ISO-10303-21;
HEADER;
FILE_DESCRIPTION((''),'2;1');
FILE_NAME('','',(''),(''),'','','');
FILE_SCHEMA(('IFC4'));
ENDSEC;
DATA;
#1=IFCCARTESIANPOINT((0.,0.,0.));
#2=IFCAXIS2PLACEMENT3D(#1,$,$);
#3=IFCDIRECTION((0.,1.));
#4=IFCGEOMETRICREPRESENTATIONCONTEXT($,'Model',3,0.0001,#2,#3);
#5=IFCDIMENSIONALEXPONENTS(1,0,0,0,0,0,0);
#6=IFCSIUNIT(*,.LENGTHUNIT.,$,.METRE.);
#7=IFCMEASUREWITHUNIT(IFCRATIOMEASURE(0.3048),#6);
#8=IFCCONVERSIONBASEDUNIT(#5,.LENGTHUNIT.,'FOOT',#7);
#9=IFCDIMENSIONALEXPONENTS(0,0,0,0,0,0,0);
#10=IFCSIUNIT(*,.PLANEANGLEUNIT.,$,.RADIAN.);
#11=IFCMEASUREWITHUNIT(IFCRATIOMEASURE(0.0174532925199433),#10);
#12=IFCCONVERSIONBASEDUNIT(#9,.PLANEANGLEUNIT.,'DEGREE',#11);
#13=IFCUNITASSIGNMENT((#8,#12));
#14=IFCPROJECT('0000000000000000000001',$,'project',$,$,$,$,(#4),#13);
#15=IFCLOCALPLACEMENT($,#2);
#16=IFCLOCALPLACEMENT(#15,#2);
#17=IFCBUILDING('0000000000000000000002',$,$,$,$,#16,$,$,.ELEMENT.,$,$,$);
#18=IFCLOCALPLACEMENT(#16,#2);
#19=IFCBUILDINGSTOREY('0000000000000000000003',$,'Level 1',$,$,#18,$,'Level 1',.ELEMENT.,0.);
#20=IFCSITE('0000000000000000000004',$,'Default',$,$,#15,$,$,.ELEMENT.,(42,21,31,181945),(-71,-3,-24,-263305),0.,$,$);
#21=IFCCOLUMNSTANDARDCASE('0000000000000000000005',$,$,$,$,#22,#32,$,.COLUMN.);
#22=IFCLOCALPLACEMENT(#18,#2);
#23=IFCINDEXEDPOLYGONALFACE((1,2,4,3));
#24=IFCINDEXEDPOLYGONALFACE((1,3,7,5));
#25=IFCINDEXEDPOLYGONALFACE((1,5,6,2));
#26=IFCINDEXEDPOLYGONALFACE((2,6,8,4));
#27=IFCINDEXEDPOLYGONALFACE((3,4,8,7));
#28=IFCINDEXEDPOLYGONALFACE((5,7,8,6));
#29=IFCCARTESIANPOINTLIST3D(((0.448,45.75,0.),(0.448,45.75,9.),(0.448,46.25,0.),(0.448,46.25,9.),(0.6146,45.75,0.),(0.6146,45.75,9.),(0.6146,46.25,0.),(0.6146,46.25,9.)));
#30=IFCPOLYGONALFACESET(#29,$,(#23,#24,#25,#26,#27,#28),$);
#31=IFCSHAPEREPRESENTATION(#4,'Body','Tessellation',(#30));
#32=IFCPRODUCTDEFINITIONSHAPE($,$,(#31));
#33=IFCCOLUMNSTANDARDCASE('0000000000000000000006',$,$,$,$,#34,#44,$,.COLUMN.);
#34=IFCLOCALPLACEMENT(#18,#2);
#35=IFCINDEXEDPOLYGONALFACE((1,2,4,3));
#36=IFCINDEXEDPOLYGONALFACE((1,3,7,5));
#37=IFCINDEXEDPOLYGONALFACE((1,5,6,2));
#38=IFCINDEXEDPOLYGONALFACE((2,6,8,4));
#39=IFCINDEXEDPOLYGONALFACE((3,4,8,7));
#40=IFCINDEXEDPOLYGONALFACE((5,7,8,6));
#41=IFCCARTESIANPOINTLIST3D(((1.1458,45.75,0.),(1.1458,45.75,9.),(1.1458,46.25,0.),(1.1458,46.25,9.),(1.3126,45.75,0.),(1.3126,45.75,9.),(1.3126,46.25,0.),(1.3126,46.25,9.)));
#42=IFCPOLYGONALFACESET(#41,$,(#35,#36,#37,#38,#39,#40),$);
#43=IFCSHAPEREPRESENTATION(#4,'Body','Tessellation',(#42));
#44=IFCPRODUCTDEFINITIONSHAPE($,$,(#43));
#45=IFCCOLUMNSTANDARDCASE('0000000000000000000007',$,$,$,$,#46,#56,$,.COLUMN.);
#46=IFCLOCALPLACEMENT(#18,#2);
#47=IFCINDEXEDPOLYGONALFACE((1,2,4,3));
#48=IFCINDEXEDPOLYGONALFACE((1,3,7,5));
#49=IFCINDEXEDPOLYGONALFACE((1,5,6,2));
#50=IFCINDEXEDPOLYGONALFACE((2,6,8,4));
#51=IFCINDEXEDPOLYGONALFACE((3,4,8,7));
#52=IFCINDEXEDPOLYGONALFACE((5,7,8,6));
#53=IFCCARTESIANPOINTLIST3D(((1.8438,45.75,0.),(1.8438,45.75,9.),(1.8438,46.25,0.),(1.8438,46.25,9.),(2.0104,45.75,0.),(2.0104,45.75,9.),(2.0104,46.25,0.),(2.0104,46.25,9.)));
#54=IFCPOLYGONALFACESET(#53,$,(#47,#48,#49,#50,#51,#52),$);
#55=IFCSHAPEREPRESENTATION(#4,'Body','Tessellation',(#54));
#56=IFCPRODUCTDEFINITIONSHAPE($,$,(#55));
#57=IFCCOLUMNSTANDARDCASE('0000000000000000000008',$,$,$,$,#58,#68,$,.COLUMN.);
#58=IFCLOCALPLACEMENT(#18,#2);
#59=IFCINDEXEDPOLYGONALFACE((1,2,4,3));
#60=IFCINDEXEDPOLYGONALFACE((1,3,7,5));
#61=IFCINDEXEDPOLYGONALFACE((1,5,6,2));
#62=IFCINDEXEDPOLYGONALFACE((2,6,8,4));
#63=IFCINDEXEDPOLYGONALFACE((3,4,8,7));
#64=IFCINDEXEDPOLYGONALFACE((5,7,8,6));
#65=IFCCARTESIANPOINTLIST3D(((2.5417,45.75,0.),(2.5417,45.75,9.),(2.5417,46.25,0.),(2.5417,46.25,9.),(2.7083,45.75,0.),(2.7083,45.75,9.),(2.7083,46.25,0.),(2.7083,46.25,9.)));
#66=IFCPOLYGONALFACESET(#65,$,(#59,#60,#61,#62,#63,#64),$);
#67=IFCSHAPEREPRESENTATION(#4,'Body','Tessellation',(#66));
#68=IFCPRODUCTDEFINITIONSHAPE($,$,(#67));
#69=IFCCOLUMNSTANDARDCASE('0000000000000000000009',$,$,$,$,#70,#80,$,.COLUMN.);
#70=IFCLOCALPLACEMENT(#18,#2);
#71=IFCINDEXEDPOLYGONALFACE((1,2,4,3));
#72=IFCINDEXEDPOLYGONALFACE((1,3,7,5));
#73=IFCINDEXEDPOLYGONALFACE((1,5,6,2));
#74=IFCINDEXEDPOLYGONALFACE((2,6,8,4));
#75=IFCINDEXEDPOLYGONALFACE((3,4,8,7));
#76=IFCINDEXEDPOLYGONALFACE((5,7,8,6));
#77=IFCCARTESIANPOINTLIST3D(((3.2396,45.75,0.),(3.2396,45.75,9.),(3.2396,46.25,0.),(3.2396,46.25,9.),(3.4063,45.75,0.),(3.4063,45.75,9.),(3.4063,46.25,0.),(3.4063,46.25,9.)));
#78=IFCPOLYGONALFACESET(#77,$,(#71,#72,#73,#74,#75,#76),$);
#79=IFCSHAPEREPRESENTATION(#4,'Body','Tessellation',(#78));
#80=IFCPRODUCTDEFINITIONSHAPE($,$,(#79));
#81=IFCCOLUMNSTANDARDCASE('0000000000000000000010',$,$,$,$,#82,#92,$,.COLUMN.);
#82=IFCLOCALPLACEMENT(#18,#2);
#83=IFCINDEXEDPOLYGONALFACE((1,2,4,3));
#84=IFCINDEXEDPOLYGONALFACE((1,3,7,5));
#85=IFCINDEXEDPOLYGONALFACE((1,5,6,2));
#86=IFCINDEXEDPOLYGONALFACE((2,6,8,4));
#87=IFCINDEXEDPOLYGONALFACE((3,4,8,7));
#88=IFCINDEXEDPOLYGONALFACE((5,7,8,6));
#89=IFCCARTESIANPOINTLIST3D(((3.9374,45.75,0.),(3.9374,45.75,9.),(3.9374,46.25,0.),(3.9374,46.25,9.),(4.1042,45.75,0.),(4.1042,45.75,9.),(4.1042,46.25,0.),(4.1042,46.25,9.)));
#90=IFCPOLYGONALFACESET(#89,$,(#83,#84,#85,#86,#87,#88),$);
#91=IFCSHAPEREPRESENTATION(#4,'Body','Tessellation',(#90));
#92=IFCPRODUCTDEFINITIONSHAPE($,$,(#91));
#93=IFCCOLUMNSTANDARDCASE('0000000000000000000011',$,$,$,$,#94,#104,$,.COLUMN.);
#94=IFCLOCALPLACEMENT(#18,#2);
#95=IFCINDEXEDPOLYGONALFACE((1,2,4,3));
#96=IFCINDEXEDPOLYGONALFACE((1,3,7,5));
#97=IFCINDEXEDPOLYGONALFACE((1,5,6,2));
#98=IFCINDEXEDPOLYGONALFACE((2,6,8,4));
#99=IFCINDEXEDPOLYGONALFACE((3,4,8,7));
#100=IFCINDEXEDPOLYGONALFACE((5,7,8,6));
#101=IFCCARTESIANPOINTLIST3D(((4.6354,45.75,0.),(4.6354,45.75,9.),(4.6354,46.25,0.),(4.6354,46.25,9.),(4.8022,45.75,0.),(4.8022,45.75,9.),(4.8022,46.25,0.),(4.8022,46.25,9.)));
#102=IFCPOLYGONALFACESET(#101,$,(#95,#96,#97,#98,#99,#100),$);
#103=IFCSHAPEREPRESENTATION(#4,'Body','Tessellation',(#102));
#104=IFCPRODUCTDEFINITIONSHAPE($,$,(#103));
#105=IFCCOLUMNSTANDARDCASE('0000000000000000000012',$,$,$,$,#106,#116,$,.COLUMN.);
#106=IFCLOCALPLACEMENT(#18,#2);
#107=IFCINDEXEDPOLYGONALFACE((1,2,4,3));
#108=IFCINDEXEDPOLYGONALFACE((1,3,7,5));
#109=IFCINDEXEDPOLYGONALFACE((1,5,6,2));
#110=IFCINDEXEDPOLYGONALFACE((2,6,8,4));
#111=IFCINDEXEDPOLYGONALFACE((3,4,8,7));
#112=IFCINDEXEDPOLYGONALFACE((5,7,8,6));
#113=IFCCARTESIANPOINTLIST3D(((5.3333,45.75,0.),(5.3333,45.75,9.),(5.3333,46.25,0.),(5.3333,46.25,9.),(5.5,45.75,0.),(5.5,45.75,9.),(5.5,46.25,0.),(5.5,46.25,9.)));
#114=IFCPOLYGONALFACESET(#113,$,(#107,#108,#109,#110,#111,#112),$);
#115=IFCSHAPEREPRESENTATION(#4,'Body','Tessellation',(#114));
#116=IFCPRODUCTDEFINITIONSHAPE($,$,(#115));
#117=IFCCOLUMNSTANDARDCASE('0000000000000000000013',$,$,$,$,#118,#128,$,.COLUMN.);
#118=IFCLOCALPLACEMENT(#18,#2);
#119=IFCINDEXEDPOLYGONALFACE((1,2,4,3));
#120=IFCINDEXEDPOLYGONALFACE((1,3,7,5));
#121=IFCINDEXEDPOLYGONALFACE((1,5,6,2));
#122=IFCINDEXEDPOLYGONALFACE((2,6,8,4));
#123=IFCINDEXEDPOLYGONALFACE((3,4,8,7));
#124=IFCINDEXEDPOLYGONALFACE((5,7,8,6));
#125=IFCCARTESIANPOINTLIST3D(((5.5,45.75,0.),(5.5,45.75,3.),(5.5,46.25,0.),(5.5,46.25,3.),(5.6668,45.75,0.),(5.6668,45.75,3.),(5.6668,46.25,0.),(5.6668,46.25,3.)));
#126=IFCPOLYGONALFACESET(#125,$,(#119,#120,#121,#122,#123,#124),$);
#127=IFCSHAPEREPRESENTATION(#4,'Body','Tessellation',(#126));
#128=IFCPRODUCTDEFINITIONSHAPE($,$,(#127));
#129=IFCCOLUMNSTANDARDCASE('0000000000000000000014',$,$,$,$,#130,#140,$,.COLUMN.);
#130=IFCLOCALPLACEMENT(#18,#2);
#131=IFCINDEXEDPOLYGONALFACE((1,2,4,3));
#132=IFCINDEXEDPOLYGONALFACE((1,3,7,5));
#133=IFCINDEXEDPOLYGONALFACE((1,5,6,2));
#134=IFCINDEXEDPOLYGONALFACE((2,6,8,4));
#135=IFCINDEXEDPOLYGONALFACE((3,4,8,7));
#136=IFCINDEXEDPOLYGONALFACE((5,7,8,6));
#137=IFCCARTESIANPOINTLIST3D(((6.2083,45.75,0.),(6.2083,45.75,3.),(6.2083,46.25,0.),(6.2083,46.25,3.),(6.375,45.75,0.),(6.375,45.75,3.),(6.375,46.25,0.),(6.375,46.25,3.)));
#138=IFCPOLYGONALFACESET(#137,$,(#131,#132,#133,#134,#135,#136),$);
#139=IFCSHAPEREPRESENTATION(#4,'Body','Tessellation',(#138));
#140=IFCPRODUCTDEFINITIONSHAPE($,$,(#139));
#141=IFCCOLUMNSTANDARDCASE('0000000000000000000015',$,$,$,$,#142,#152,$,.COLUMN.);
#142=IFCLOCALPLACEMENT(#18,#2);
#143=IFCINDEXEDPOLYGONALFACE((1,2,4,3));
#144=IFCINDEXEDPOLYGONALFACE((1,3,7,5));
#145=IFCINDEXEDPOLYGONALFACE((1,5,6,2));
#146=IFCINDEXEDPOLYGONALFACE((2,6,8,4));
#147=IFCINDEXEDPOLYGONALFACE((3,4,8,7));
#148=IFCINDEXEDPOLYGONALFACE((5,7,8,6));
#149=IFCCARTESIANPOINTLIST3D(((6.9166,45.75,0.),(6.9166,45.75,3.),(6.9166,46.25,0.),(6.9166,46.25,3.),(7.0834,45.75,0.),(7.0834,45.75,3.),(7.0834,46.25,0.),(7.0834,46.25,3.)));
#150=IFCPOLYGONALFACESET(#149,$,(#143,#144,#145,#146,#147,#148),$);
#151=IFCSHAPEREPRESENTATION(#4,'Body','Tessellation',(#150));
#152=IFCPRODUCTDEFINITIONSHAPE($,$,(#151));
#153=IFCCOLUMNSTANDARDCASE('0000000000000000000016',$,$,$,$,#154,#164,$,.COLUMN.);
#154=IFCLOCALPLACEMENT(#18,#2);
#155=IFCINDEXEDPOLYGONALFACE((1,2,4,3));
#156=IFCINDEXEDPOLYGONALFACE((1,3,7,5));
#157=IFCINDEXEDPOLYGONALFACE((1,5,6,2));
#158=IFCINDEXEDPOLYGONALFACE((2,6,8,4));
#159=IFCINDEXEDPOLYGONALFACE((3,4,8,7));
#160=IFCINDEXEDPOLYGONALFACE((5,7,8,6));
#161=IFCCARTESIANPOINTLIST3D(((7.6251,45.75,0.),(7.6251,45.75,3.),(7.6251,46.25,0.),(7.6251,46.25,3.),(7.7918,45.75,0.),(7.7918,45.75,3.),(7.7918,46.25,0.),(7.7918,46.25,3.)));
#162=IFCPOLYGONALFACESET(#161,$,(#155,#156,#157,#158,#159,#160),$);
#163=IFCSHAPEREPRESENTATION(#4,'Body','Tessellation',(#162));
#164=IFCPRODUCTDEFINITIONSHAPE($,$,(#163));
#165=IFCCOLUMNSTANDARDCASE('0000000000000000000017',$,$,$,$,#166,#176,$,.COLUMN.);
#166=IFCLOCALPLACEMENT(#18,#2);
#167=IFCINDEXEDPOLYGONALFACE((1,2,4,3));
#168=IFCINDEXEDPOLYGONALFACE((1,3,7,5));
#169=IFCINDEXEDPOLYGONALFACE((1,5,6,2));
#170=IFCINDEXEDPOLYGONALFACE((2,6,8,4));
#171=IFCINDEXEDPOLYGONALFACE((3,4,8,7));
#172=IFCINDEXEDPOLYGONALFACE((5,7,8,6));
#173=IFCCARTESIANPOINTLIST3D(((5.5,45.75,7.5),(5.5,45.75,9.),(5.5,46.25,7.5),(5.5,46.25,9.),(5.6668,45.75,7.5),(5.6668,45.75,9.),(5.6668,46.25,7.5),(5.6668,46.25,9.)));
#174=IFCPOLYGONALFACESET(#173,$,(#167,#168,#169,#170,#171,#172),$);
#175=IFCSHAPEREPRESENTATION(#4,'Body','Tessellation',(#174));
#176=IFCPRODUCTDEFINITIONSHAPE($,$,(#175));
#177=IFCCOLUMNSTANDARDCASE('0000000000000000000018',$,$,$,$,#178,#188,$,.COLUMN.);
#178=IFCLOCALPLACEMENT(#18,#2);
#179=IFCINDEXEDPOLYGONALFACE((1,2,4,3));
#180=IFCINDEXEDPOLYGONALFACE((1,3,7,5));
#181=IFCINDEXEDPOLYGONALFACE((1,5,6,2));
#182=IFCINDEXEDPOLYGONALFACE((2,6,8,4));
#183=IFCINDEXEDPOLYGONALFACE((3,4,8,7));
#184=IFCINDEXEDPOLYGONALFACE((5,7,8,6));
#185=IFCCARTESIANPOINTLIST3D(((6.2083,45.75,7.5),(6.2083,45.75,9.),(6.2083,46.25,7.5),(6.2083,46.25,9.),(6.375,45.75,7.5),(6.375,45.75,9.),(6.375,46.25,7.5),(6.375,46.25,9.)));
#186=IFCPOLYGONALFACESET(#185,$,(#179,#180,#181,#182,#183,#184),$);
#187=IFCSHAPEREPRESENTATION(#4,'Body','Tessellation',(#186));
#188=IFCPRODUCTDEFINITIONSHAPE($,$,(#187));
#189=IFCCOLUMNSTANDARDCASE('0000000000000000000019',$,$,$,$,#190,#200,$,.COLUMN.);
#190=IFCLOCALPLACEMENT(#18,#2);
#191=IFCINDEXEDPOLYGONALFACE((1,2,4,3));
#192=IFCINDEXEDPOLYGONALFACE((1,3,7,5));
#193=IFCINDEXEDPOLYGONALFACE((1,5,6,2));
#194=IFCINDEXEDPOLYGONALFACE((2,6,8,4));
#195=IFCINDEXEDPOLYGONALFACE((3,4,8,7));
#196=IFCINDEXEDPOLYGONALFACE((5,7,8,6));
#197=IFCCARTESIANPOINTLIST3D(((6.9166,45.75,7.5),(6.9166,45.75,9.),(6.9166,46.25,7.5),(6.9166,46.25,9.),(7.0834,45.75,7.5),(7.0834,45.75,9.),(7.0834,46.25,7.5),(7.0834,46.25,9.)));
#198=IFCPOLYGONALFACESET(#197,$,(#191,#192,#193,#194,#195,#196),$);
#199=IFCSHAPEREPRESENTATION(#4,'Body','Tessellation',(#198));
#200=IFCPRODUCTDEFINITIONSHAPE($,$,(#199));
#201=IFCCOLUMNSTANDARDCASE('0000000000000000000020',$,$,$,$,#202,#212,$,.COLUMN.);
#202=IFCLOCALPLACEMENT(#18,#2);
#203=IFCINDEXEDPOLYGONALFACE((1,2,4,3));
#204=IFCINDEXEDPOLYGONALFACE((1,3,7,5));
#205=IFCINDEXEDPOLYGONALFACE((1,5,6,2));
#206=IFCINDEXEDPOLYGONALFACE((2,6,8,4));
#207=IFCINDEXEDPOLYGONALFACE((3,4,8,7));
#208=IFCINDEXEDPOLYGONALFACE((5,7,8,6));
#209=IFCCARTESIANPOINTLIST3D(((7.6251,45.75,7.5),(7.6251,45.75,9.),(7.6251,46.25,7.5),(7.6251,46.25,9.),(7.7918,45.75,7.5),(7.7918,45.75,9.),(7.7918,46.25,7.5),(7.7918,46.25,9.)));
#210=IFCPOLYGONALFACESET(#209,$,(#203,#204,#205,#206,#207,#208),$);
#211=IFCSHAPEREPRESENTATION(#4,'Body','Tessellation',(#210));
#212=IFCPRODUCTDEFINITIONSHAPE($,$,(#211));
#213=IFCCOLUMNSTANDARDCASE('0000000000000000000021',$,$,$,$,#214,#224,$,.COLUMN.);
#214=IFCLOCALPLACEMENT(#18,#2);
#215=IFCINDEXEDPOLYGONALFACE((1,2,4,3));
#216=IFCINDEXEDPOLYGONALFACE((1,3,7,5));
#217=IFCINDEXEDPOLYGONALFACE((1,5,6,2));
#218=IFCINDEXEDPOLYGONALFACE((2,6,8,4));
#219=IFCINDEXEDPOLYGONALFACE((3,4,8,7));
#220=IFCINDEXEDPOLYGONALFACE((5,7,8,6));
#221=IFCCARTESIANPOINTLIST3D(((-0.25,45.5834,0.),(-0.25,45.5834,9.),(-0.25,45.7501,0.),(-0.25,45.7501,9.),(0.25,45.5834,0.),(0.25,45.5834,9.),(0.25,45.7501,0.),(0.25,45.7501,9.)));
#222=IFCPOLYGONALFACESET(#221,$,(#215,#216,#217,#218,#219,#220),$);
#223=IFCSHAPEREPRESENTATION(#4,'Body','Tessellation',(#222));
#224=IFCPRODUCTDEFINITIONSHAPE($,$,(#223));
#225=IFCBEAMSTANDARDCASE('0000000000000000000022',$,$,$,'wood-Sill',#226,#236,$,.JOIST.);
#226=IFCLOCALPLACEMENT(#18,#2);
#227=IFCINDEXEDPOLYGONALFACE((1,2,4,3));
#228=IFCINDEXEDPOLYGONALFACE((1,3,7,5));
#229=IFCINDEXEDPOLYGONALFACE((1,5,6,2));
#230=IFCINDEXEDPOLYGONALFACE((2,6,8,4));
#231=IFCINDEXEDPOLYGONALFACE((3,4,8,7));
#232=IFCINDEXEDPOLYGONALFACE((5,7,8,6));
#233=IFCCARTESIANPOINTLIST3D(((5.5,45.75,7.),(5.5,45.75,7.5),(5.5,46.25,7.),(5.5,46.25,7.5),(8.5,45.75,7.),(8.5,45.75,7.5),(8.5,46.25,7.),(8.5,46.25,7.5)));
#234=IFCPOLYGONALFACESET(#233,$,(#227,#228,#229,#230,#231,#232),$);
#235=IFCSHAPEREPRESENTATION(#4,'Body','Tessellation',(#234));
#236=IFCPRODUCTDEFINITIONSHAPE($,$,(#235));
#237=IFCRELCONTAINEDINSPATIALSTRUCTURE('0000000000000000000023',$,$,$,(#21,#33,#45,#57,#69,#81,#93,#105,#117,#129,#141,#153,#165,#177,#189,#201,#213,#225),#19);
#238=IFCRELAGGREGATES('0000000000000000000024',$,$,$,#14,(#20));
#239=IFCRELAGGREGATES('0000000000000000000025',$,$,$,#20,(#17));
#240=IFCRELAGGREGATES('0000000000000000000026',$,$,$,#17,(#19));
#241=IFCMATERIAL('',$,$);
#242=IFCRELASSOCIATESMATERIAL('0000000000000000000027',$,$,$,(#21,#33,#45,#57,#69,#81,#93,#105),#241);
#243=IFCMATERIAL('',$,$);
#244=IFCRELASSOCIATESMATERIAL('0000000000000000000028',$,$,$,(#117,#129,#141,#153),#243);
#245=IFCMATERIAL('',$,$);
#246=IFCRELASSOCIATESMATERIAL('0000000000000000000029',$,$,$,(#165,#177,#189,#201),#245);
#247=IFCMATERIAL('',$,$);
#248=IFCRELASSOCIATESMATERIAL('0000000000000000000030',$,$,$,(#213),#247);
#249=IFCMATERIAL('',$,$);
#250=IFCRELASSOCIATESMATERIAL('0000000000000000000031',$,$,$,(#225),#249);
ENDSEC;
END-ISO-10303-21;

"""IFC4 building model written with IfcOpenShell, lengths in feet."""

from ifc_helpers import new_model, entity, si_unit, converted_unit, direction, frame, origin, place, context, project, spatial, rectangle, extrude, material, element, save


model = new_model("IFC4")

# Units and contexts
model_context = context("Model", 3, precision=0.0001, world=origin(), true_north=direction((0.0, 1.0)))
ifc_project = project(units=[converted_unit("LENGTHUNIT", "FOOT", entity("IfcRatioMeasure", 0.3048), si_unit("LENGTHUNIT", "METRE"), dimensions=[1, 0, 0, 0, 0, 0, 0]), converted_unit("PLANEANGLEUNIT", "DEGREE", entity("IfcRatioMeasure", 0.0174532925199433), si_unit("PLANEANGLEUNIT", "RADIAN"), dimensions=[0, 0, 0, 0, 0, 0, 0])], contexts=[model_context])

# Site, building, storey
site_placement = place(None, origin())
site = spatial("IfcSite", under=ifc_project, at=site_placement, Name="Default", CompositionType="ELEMENT", RefLatitude=(42, 21, 31, 181945), RefLongitude=(-71, -3, -24, -263305), RefElevation=0.0)
building_placement = place(site_placement, origin())
building = spatial("IfcBuilding", under=site, at=building_placement, CompositionType="ELEMENT")
storey_placement = place(building_placement, origin())
storey = spatial("IfcBuildingStorey", under=building, at=storey_placement, Name="Level 1", LongName="Level 1", CompositionType="ELEMENT", Elevation=0.0)

# Columns
ifc_material_1 = material(Name="")
placement_1 = place(storey_placement, frame((-0.25, 46.0, 0.0)))
for number, where, z_axis, x_axis in (
    (1, (0.7813, 0.0, 0.0), (0.0, 0.0, 1.0), (1.0, 0.0, 0.0)),
    (2, (1.4792, 0.0, 0.0), (0.0, 0.0, 1.0), (1.0, 0.0, 0.0)),
    (3, (2.1771, 0.0, 0.0), (0.0, 0.0, 1.0), (1.0, 0.0, 0.0)),
    (4, (2.875, 0.0, 0.0), (0.0, 0.0, 1.0), (1.0, 0.0, 0.0)),
    (5, (3.5729, 0.0, 0.0), (0.0, 0.0, 1.0), (1.0, 0.0, 0.0)),
    (6, (4.2708, 0.0, 0.0), (0.0, 0.0, 1.0), (1.0, 0.0, 0.0)),
    (7, (4.9688, 0.0, 0.0), (0.0, 0.0, 1.0), (1.0, 0.0, 0.0)),
    (8, (5.6667, 0.0, 0.0), (0.0, 0.0, 1.0), (1.0, 0.0, 0.0)),
):
    element("IfcColumnStandardCase", number, at=place(placement_1, frame(where, z_axis=z_axis, x_axis=x_axis)), inside=storey, material=ifc_material_1, PredefinedType="COLUMN", context=model_context, shape_type="SweptSolid", body=[
        extrude(rectangle(XDim=0.1667, YDim=0.5), origin(), (0.0, 0.0, 1.0), 9.0),
    ])
ifc_material_2 = material(Name="")
for number, where, z_axis, x_axis in (
    (9, (5.8334, 0.0, 0.0), (0.0, 0.0, 1.0), (1.0, 0.0, 0.0)),
    (10, (6.5417, 0.0, 0.0), (0.0, 0.0, 1.0), (1.0, 0.0, 0.0)),
    (11, (7.25, 0.0, 0.0), (0.0, 0.0, 1.0), (1.0, 0.0, 0.0)),
    (12, (7.9584, 0.0, 0.0), (0.0, 0.0, 1.0), (1.0, 0.0, 0.0)),
):
    element("IfcColumnStandardCase", number, at=place(placement_1, frame(where, z_axis=z_axis, x_axis=x_axis)), inside=storey, material=ifc_material_2, PredefinedType="COLUMN", context=model_context, shape_type="SweptSolid", body=[
        extrude(rectangle(XDim=0.1667, YDim=0.5), origin(), (0.0, 0.0, 1.0), 3.0),
    ])
ifc_material_3 = material(Name="")
for number, where, z_axis, x_axis in (
    (13, (5.8334, 0.0, 7.5), (0.0, 0.0, 1.0), (1.0, 0.0, 0.0)),
    (14, (6.5417, 0.0, 7.5), (0.0, 0.0, 1.0), (1.0, 0.0, 0.0)),
    (15, (7.25, 0.0, 7.5), (0.0, 0.0, 1.0), (1.0, 0.0, 0.0)),
    (16, (7.9584, 0.0, 7.5), (0.0, 0.0, 1.0), (1.0, 0.0, 0.0)),
):
    element("IfcColumnStandardCase", number, at=place(placement_1, frame(where, z_axis=z_axis, x_axis=x_axis)), inside=storey, material=ifc_material_3, PredefinedType="COLUMN", context=model_context, shape_type="SweptSolid", body=[
        extrude(rectangle(XDim=0.1667, YDim=0.5), origin(), (0.0, 0.0, 1.0), 1.5),
    ])
ifc_material_4 = material(Name="")
placement_2 = place(storey_placement, frame((0.0, -0.25, 0.0), z_axis=(0.0, 0.0, 1.0), x_axis=(0.0, 1.0, 0.0)))
column_placement = place(placement_2, frame((45.9167, 0.0, 0.0), z_axis=(0.0, 0.0, 1.0), x_axis=(1.0, 0.0, 0.0)))
element("IfcColumnStandardCase", 17, at=column_placement, inside=storey, material=ifc_material_4, PredefinedType="COLUMN", context=model_context, shape_type="SweptSolid", body=[
    extrude(rectangle(XDim=0.1667, YDim=0.5), origin(), (0.0, 0.0, 1.0), 9.0),
])

# Beam
ifc_material_5 = material(Name="")
for number, where, z_axis, x_axis in (
    (18, (7.25, 0.0, 7.0), (0.0, 0.0, 1.0), (-1.0, 0.0, 0.0)),
):
    element("IfcBeamStandardCase", number, at=place(placement_1, frame(where, z_axis=z_axis, x_axis=x_axis)), inside=storey, material=ifc_material_5, ObjectType="wood-Sill", PredefinedType="JOIST", context=model_context, shape_type="SweptSolid", body=[
        extrude(rectangle(XDim=3.0, YDim=0.5), origin(), (0.0, 0.0, 1.0), 0.5),
    ])

save(model, "model.ifc")
